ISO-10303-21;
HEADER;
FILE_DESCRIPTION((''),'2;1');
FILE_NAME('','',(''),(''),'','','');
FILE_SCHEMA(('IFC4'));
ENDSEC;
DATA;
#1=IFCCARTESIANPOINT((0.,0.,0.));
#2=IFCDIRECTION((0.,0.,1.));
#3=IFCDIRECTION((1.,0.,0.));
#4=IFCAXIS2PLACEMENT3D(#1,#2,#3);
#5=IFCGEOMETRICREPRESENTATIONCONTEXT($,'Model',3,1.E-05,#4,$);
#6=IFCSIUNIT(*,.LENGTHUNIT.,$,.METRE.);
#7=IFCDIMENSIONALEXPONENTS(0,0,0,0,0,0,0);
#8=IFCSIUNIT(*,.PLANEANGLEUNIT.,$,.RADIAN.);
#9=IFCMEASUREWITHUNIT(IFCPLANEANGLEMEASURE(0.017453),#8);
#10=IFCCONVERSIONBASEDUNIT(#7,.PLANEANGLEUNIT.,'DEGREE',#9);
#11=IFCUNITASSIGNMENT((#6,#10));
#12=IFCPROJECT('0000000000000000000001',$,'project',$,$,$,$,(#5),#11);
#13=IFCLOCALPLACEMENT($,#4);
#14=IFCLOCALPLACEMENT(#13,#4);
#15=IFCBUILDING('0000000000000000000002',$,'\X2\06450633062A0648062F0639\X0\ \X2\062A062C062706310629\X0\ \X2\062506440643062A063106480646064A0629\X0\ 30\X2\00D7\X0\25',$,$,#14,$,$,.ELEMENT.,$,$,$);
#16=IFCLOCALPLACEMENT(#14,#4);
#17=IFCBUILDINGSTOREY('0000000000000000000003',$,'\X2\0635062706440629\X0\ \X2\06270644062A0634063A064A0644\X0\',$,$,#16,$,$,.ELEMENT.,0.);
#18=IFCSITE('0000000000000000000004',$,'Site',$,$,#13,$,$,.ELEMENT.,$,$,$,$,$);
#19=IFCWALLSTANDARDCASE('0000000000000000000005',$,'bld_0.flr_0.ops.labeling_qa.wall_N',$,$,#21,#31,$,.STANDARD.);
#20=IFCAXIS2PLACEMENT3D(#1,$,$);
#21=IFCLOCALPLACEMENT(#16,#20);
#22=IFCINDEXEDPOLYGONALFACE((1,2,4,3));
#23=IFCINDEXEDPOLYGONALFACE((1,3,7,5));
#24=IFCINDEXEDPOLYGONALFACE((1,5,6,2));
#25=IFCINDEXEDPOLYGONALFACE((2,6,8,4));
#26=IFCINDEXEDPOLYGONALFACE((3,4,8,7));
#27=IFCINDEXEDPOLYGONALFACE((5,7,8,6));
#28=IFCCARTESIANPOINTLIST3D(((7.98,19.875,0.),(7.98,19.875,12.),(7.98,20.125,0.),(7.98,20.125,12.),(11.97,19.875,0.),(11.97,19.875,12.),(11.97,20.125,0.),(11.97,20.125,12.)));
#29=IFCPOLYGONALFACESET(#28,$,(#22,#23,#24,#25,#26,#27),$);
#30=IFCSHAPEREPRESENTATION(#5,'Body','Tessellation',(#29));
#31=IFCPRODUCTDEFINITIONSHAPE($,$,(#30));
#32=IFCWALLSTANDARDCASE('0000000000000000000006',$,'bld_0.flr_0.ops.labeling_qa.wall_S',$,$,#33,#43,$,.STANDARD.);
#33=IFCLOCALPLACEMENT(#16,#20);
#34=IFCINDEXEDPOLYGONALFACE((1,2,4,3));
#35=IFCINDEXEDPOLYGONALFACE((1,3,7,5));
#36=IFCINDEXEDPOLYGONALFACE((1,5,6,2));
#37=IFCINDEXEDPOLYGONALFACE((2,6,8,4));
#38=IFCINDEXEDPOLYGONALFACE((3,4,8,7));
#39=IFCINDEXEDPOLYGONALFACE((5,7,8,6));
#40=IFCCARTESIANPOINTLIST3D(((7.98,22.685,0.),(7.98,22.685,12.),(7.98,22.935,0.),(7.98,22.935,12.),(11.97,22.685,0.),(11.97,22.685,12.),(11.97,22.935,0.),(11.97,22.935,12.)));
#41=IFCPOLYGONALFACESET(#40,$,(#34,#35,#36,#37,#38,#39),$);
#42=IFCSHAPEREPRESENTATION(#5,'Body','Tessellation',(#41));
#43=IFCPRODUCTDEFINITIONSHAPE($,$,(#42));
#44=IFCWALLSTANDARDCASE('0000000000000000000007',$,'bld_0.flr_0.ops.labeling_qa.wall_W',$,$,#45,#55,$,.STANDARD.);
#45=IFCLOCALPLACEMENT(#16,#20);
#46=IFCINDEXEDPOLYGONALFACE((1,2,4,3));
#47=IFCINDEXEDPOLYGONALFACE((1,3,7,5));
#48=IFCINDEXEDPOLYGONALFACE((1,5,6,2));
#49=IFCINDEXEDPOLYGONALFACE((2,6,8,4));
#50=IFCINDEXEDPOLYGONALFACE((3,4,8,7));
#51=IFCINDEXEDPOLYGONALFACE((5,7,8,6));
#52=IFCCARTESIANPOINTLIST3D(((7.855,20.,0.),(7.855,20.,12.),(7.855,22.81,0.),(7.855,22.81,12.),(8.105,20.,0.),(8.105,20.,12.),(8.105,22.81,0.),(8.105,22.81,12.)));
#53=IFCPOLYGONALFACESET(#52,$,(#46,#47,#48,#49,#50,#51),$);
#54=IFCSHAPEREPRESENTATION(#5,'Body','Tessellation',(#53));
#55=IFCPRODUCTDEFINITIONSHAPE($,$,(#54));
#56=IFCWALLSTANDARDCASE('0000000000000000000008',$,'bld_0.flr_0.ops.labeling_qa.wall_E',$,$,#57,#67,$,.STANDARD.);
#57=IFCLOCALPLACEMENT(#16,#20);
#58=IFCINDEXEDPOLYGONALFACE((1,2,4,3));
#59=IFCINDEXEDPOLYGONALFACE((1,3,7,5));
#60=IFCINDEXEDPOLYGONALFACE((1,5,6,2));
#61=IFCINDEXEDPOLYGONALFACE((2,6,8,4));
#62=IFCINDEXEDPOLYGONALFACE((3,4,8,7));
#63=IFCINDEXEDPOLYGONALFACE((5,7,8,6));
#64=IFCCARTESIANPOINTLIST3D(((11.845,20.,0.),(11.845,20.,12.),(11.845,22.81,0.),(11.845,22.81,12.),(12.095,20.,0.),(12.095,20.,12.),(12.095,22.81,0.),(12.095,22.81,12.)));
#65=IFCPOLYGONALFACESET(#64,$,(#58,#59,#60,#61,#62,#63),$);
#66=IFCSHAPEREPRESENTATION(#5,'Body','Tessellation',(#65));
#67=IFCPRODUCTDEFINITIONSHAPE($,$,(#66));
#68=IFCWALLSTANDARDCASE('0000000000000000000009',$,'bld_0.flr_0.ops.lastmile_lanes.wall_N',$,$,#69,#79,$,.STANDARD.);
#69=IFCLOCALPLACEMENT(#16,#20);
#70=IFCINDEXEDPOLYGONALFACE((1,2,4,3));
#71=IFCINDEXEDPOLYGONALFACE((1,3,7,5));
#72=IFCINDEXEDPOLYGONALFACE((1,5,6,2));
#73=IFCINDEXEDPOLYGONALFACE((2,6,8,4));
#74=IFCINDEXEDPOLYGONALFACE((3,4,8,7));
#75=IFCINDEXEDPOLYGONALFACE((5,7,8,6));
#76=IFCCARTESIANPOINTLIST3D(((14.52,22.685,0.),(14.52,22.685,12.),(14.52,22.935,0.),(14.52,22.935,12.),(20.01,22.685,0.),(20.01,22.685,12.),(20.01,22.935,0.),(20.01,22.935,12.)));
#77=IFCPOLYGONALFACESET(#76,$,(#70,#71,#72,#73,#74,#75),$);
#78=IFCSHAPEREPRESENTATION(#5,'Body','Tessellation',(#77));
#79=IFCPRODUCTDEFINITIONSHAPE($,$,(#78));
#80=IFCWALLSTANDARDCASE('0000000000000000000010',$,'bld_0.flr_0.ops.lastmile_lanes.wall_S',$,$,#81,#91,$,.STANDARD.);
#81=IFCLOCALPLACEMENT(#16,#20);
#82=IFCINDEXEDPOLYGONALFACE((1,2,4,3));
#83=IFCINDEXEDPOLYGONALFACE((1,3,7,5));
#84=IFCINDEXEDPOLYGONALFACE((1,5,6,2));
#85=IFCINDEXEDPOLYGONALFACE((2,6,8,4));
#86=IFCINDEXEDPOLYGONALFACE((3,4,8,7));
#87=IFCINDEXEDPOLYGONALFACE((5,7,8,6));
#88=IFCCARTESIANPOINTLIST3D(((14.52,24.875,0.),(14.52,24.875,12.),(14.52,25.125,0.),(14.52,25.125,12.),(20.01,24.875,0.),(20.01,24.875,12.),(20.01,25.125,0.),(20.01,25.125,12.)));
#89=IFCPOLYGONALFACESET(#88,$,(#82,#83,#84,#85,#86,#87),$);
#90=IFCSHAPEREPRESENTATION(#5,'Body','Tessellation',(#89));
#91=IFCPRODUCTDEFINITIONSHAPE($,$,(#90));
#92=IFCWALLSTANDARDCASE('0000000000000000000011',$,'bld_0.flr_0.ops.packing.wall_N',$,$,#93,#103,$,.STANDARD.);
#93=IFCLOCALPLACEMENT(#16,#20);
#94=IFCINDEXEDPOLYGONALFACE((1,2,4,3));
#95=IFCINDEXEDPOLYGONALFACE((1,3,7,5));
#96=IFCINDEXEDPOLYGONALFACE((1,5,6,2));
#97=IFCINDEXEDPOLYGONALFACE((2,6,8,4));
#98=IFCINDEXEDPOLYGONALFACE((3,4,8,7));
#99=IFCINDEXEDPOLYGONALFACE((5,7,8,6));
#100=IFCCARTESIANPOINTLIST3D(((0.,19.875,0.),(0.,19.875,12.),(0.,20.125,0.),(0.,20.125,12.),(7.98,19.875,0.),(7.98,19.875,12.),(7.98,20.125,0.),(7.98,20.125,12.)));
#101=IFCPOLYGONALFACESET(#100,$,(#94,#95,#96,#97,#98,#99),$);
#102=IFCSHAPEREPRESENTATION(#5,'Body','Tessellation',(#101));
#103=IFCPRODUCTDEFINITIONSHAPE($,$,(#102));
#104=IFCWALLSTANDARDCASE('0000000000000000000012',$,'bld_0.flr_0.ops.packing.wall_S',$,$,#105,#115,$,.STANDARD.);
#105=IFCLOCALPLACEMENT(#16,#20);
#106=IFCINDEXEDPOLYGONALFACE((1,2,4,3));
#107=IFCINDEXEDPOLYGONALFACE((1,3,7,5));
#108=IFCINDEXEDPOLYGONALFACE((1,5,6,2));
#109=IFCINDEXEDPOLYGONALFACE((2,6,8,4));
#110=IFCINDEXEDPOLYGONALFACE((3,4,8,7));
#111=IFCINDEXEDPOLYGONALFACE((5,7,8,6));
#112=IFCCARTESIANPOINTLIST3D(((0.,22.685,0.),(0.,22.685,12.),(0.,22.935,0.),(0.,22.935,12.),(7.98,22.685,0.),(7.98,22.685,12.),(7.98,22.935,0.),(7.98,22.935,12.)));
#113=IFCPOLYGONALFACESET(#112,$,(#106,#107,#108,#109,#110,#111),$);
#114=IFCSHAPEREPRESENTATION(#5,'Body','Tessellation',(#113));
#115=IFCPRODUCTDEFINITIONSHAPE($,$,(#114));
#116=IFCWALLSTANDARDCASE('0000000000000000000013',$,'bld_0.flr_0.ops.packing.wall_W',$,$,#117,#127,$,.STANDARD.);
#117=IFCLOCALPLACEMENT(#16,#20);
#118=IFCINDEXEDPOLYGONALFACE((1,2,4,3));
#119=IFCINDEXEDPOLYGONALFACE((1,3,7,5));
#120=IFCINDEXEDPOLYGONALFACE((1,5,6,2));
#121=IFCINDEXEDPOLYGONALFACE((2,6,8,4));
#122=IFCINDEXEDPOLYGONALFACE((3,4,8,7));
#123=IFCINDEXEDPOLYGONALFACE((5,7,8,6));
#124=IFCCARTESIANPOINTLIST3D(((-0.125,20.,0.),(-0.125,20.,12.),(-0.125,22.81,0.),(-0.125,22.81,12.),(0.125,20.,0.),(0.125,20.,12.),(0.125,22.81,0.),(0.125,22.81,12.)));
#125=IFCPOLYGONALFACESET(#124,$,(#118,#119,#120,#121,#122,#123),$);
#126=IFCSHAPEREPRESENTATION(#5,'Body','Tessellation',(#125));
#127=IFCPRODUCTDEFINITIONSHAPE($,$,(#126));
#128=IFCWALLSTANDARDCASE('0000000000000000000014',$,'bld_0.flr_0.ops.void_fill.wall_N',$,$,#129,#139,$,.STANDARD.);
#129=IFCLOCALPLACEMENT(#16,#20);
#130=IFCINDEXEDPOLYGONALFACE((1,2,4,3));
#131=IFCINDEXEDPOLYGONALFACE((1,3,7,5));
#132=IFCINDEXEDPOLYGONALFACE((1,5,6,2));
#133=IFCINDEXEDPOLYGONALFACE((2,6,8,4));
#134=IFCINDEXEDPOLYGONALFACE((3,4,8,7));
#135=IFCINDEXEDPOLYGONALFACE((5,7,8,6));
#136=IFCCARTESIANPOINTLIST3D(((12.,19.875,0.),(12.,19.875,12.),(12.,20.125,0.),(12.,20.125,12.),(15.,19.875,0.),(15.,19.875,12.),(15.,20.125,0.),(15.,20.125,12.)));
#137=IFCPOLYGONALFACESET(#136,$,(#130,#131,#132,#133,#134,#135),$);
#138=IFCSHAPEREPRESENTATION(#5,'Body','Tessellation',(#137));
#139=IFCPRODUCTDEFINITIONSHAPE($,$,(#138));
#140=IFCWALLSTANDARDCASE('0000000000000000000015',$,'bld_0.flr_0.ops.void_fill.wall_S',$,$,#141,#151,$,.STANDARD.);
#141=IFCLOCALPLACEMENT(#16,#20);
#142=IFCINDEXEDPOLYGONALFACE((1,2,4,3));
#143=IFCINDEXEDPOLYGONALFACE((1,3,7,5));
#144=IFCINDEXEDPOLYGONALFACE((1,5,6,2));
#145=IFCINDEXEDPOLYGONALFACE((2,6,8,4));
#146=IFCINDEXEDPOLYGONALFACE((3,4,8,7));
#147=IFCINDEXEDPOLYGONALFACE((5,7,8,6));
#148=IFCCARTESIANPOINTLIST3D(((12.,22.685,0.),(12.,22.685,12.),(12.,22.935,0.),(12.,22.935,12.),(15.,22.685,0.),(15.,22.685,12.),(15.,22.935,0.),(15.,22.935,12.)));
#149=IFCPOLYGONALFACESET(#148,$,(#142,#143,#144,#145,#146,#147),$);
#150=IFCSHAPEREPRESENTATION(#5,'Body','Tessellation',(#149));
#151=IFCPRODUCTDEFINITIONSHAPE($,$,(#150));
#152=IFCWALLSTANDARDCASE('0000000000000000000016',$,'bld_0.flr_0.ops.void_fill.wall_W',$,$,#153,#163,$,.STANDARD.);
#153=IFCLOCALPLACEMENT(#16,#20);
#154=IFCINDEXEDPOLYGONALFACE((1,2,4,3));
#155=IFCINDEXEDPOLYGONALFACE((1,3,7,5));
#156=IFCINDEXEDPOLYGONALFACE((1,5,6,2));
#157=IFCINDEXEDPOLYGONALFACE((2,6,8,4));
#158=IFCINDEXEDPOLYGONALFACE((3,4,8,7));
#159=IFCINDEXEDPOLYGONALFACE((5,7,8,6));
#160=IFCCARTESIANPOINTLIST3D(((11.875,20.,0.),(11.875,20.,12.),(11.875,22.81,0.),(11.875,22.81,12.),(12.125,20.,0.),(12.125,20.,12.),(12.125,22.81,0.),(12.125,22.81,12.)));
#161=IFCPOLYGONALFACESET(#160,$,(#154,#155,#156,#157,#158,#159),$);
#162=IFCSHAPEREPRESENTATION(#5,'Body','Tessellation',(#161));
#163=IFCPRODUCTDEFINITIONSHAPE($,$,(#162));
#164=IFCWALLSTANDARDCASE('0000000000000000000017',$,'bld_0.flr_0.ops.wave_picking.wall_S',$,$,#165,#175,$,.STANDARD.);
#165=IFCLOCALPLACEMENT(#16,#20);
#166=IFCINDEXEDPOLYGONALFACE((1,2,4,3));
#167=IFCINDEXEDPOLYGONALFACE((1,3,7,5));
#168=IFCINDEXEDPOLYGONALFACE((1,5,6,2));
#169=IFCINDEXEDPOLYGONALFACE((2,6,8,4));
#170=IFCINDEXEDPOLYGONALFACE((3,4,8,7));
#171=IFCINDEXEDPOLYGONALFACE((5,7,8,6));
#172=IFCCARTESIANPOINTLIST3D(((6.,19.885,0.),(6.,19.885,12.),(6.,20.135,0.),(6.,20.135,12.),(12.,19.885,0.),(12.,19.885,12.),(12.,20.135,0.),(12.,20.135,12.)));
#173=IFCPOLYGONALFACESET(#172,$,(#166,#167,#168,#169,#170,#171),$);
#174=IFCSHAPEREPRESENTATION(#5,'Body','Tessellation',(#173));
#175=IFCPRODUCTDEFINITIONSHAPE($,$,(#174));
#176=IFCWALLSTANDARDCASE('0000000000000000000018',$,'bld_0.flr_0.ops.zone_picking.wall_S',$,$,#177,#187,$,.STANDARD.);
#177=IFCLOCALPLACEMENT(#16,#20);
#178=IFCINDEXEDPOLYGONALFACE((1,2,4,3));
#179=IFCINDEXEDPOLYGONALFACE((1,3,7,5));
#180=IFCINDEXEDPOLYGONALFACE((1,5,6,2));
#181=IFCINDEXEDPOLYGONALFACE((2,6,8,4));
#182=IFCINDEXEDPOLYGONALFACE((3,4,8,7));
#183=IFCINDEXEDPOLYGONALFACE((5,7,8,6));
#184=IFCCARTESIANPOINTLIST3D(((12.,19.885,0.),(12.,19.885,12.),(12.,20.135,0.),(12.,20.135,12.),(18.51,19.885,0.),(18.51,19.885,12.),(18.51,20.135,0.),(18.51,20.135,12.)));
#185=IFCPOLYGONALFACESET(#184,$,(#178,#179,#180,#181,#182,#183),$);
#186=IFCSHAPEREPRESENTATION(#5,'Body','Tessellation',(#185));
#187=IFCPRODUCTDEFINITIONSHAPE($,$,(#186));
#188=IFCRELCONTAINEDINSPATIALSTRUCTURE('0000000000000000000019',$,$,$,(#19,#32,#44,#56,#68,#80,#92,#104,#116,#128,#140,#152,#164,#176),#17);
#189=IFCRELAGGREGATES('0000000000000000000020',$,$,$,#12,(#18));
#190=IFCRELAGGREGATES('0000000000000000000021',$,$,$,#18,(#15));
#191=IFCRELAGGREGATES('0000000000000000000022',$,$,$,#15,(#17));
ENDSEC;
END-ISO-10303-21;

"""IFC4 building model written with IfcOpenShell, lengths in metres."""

from ifc_helpers import new_model, entity, si_unit, converted_unit, frame, frame_2d, origin_with_axes, place, context, project, spatial, rectangle, extrude, element, save


model = new_model("IFC4")

# Units and contexts
model_context = context("Model", 3, precision=1e-05, world=origin_with_axes())
ifc_project = project(units=[si_unit("LENGTHUNIT", "METRE"), converted_unit("PLANEANGLEUNIT", "DEGREE", entity("IfcPlaneAngleMeasure", 0.017453), si_unit("PLANEANGLEUNIT", "RADIAN"), dimensions=[0, 0, 0, 0, 0, 0, 0])], contexts=[model_context])

# Site, building, storey
site_placement = place(None, origin_with_axes())
site = spatial("IfcSite", under=ifc_project, at=site_placement, Name="Site", CompositionType="ELEMENT")
building_placement = place(site_placement, origin_with_axes())
building = spatial("IfcBuilding", under=site, at=building_placement, Name="مستودع تجارة إلكترونية 30×25", CompositionType="ELEMENT")
storey_placement = place(building_placement, origin_with_axes())
storey = spatial("IfcBuildingStorey", under=building, at=storey_placement, Name="صالة التشغيل", CompositionType="ELEMENT", Elevation=0.0)

# Walls
for number, where, z_axis, x_axis, name in (
    (1, (7.98, 20.0, 0.0), (0.0, 0.0, 1.0), (1.0, 0.0, 0.0), "bld_0.flr_0.ops.labeling_qa.wall_N"),
    (2, (7.98, 22.81, 0.0), (0.0, 0.0, 1.0), (1.0, 0.0, 0.0), "bld_0.flr_0.ops.labeling_qa.wall_S"),
):
    element("IfcWallStandardCase", number, at=place(storey_placement, frame(where, z_axis=z_axis, x_axis=x_axis)), inside=storey, Name=name, PredefinedType="STANDARD", context=model_context, shape_type="SweptSolid", body=[
        extrude(rectangle(XDim=3.99, YDim=0.25, at=frame_2d((1.995, 0.0), x_axis=(1.0, 0.0))), origin_with_axes(), (0.0, 0.0, 1.0), 12.0),
    ])
for number, where, z_axis, x_axis, name in (
    (3, (7.98, 20.0, 0.0), (0.0, 0.0, 1.0), (0.0, 1.0, 0.0), "bld_0.flr_0.ops.labeling_qa.wall_W"),
    (4, (11.97, 20.0, 0.0), (0.0, 0.0, 1.0), (0.0, 1.0, 0.0), "bld_0.flr_0.ops.labeling_qa.wall_E"),
):
    element("IfcWallStandardCase", number, at=place(storey_placement, frame(where, z_axis=z_axis, x_axis=x_axis)), inside=storey, Name=name, PredefinedType="STANDARD", context=model_context, shape_type="SweptSolid", body=[
        extrude(rectangle(XDim=2.81, YDim=0.25, at=frame_2d((1.405, 0.0), x_axis=(1.0, 0.0))), origin_with_axes(), (0.0, 0.0, 1.0), 12.0),
    ])
for number, where, z_axis, x_axis, name in (
    (5, (14.52, 22.81, 0.0), (0.0, 0.0, 1.0), (1.0, 0.0, 0.0), "bld_0.flr_0.ops.lastmile_lanes.wall_N"),
    (6, (14.52, 25.0, 0.0), (0.0, 0.0, 1.0), (1.0, 0.0, 0.0), "bld_0.flr_0.ops.lastmile_lanes.wall_S"),
):
    element("IfcWallStandardCase", number, at=place(storey_placement, frame(where, z_axis=z_axis, x_axis=x_axis)), inside=storey, Name=name, PredefinedType="STANDARD", context=model_context, shape_type="SweptSolid", body=[
        extrude(rectangle(XDim=5.49, YDim=0.25, at=frame_2d((2.745, 0.0), x_axis=(1.0, 0.0))), origin_with_axes(), (0.0, 0.0, 1.0), 12.0),
    ])
for number, where, z_axis, x_axis, name in (
    (7, (0.0, 20.0, 0.0), (0.0, 0.0, 1.0), (1.0, 0.0, 0.0), "bld_0.flr_0.ops.packing.wall_N"),
    (8, (0.0, 22.81, 0.0), (0.0, 0.0, 1.0), (1.0, 0.0, 0.0), "bld_0.flr_0.ops.packing.wall_S"),
):
    element("IfcWallStandardCase", number, at=place(storey_placement, frame(where, z_axis=z_axis, x_axis=x_axis)), inside=storey, Name=name, PredefinedType="STANDARD", context=model_context, shape_type="SweptSolid", body=[
        extrude(rectangle(XDim=7.98, YDim=0.25, at=frame_2d((3.99, 0.0), x_axis=(1.0, 0.0))), origin_with_axes(), (0.0, 0.0, 1.0), 12.0),
    ])
for number, where, z_axis, x_axis, name in (
    (9, (0.0, 20.0, 0.0), (0.0, 0.0, 1.0), (0.0, 1.0, 0.0), "bld_0.flr_0.ops.packing.wall_W"),
):
    element("IfcWallStandardCase", number, at=place(storey_placement, frame(where, z_axis=z_axis, x_axis=x_axis)), inside=storey, Name=name, PredefinedType="STANDARD", context=model_context, shape_type="SweptSolid", body=[
        extrude(rectangle(XDim=2.81, YDim=0.25, at=frame_2d((1.405, 0.0), x_axis=(1.0, 0.0))), origin_with_axes(), (0.0, 0.0, 1.0), 12.0),
    ])
for number, where, z_axis, x_axis, name in (
    (10, (12.0, 20.0, 0.0), (0.0, 0.0, 1.0), (1.0, 0.0, 0.0), "bld_0.flr_0.ops.void_fill.wall_N"),
    (11, (12.0, 22.81, 0.0), (0.0, 0.0, 1.0), (1.0, 0.0, 0.0), "bld_0.flr_0.ops.void_fill.wall_S"),
):
    element("IfcWallStandardCase", number, at=place(storey_placement, frame(where, z_axis=z_axis, x_axis=x_axis)), inside=storey, Name=name, PredefinedType="STANDARD", context=model_context, shape_type="SweptSolid", body=[
        extrude(rectangle(XDim=3.0, YDim=0.25, at=frame_2d((1.5, 0.0), x_axis=(1.0, 0.0))), origin_with_axes(), (0.0, 0.0, 1.0), 12.0),
    ])
for number, where, z_axis, x_axis, name in (
    (12, (12.0, 20.0, 0.0), (0.0, 0.0, 1.0), (0.0, 1.0, 0.0), "bld_0.flr_0.ops.void_fill.wall_W"),
):
    element("IfcWallStandardCase", number, at=place(storey_placement, frame(where, z_axis=z_axis, x_axis=x_axis)), inside=storey, Name=name, PredefinedType="STANDARD", context=model_context, shape_type="SweptSolid", body=[
        extrude(rectangle(XDim=2.81, YDim=0.25, at=frame_2d((1.405, 0.0), x_axis=(1.0, 0.0))), origin_with_axes(), (0.0, 0.0, 1.0), 12.0),
    ])
wall_1_placement = place(storey_placement, frame((6.0, 20.01, 0.0), z_axis=(0.0, 0.0, 1.0), x_axis=(1.0, 0.0, 0.0)))
element("IfcWallStandardCase", 13, at=wall_1_placement, inside=storey, Name="bld_0.flr_0.ops.wave_picking.wall_S", PredefinedType="STANDARD", context=model_context, shape_type="SweptSolid", body=[
    extrude(rectangle(XDim=6.0, YDim=0.25, at=frame_2d((3.0, 0.0), x_axis=(1.0, 0.0))), origin_with_axes(), (0.0, 0.0, 1.0), 12.0),
])
wall_2_placement = place(storey_placement, frame((12.0, 20.01, 0.0), z_axis=(0.0, 0.0, 1.0), x_axis=(1.0, 0.0, 0.0)))
element("IfcWallStandardCase", 14, at=wall_2_placement, inside=storey, Name="bld_0.flr_0.ops.zone_picking.wall_S", PredefinedType="STANDARD", context=model_context, shape_type="SweptSolid", body=[
    extrude(rectangle(XDim=6.51, YDim=0.25, at=frame_2d((3.255, 0.0), x_axis=(1.0, 0.0))), origin_with_axes(), (0.0, 0.0, 1.0), 12.0),
])

save(model, "model.ifc")
